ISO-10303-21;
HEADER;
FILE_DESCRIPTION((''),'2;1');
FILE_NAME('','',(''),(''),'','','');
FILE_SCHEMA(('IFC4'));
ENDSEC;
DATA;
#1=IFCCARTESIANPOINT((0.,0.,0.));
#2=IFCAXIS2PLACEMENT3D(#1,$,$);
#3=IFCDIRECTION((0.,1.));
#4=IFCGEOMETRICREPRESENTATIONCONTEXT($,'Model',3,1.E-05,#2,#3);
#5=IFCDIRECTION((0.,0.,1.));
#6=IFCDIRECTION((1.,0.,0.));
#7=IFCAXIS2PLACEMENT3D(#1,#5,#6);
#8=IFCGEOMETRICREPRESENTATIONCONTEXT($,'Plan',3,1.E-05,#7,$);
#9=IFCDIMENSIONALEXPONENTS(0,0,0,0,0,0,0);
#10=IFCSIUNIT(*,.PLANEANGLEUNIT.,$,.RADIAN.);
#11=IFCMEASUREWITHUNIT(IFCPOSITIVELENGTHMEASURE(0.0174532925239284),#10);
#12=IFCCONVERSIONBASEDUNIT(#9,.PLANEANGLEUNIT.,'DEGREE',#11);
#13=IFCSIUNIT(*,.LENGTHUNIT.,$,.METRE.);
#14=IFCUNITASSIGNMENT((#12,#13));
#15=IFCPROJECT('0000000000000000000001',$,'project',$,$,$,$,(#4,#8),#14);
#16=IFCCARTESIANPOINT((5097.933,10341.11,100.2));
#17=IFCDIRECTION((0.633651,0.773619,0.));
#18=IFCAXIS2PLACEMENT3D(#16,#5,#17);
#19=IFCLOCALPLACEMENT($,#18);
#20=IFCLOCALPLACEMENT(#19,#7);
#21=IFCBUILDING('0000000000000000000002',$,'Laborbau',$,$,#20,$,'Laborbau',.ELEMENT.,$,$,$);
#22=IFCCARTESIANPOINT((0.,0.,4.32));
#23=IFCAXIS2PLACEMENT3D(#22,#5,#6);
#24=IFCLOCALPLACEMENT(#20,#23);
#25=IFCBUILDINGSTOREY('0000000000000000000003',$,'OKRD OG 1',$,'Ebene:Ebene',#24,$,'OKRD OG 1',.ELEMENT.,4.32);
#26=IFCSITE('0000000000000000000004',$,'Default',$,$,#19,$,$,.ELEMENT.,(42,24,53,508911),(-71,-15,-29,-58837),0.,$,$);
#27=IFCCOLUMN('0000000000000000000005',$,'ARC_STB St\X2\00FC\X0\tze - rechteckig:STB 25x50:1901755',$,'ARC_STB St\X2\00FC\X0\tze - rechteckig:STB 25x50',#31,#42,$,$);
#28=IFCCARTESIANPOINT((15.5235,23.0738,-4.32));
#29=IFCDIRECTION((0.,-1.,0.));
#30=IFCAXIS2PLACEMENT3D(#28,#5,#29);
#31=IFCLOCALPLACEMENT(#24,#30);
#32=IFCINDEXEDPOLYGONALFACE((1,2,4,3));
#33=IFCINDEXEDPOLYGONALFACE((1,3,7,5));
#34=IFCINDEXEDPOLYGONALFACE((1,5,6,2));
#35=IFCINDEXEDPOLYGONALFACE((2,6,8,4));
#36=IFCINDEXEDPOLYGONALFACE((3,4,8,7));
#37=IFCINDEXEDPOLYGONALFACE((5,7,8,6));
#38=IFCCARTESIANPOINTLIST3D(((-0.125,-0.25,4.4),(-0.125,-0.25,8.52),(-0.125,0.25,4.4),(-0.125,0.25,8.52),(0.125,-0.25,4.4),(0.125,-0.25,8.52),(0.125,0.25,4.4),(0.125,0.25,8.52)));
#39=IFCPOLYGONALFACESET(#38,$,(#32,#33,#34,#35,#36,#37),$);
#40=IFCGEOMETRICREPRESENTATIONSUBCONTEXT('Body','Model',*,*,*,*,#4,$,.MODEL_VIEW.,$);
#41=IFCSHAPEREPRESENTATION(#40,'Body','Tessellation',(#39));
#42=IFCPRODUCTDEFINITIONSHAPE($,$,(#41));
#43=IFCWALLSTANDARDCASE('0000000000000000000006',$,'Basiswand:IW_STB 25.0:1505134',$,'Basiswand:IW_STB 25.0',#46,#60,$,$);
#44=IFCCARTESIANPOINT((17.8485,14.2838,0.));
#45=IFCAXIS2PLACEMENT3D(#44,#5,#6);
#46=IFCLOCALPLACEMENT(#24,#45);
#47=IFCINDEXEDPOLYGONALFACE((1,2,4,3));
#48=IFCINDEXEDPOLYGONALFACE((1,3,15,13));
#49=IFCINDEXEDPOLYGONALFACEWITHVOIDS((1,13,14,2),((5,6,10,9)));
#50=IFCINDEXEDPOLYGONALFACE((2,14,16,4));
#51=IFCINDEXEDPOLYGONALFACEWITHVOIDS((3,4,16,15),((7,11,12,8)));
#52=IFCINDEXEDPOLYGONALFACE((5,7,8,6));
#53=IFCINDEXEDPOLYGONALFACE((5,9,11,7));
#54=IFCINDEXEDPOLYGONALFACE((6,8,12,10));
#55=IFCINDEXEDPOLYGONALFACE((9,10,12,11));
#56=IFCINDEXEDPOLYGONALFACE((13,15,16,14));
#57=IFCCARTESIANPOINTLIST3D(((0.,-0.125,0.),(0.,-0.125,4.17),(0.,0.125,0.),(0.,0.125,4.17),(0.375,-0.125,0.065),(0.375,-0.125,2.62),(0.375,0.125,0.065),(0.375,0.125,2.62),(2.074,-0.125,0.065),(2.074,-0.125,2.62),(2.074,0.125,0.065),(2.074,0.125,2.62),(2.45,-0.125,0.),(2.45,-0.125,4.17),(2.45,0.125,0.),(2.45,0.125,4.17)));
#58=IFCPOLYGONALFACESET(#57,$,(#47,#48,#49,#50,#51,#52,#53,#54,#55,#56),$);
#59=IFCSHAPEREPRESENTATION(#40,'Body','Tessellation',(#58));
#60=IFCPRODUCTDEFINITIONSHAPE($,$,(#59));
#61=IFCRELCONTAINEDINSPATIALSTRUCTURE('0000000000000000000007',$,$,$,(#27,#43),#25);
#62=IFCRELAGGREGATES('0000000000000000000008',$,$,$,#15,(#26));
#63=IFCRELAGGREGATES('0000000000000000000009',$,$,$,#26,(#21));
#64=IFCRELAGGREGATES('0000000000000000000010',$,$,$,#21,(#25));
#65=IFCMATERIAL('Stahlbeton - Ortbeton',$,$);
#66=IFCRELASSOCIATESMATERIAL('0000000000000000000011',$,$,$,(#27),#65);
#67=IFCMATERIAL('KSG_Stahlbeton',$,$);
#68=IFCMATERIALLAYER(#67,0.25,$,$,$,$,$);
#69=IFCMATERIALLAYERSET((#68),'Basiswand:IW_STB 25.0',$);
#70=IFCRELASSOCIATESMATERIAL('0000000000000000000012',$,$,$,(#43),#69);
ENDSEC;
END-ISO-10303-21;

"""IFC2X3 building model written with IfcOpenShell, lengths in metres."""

from ifc_helpers import new_model, entity, si_unit, converted_unit, direction, frame, frame_2d, origin, origin_with_axes, origin_2d_with_axis, place, context, subcontext, project, spatial, rectangle, extrude, source, transform, mapped, material, layer, layer_set, layer_usage, element, save


model = new_model("IFC2X3")

# Units and contexts
model_context = context("Model", 3, precision=1e-05, world=origin(), true_north=direction((0.0, 1.0)))
plan_context = context("Plan", 3, precision=1e-05, world=origin_with_axes())
body_context = subcontext(model_context, "Body", "Model", "MODEL_VIEW")
ifc_project = project(units=[converted_unit("PLANEANGLEUNIT", "DEGREE", entity("IfcPositiveLengthMeasure", 0.0174532925239284), si_unit("PLANEANGLEUNIT", "RADIAN"), dimensions=[0, 0, 0, 0, 0, 0, 0]), si_unit("LENGTHUNIT", "METRE")], contexts=[model_context, plan_context])

# Site, building, storey
site_placement = place(None, frame((5097.933, 10341.11, 100.2), z_axis=(0.0, 0.0, 1.0), x_axis=(0.633651, 0.773619, 0.0)))
site = spatial("IfcSite", under=ifc_project, at=site_placement, Name="Default", CompositionType="ELEMENT", RefLatitude=(42, 24, 53, 508911), RefLongitude=(-71, -15, -29, -58837), RefElevation=0.0)
building_placement = place(site_placement, origin_with_axes())
building = spatial("IfcBuilding", under=site, at=building_placement, Name="Laborbau", LongName="Laborbau", CompositionType="ELEMENT")
storey_placement = place(building_placement, frame((0.0, 0.0, 4.32), z_axis=(0.0, 0.0, 1.0), x_axis=(1.0, 0.0, 0.0)))
storey = spatial("IfcBuildingStorey", under=building, at=storey_placement, Name="OKRD OG 1", ObjectType="Ebene:Ebene", LongName="OKRD OG 1", CompositionType="ELEMENT", Elevation=4.32)

# Column
ifc_material_1 = material(Name="Stahlbeton - Ortbeton")
shared_shape = source(origin(), body_context, "Body", "SweptSolid", [
    extrude(rectangle(XDim=0.5, YDim=0.25, at=origin_2d_with_axis()), frame((0.0, 0.0, 4.4), z_axis=(0.0, 0.0, 1.0), x_axis=(0.0, -1.0, 0.0)), (0.0, 0.0, 1.0), 4.12),
])
column_placement = place(storey_placement, frame((15.5235, 23.0738, -4.32), z_axis=(0.0, 0.0, 1.0), x_axis=(0.0, -1.0, 0.0)))
element("IfcColumn", 1, at=column_placement, inside=storey, material=ifc_material_1, Name="ARC_STB Stütze - rechteckig:STB 25x50:1901755", ObjectType="ARC_STB Stütze - rechteckig:STB 25x50", context=body_context, shape_type="MappedRepresentation", body=[
    mapped(shared_shape, transform((0.0, 0.0, 0.0), scale=1.0)),
])

# Shared definitions
ifc_material_2 = material(Name="KSG_Stahlbeton")
ifc_layer_1 = layer(ifc_material_2, 0.25)
ifc_layer_set_1 = layer_set([ifc_layer_1], Name="Basiswand:IW_STB 25.0")

# Wall, openings
ifc_layer_usage_1 = layer_usage(ifc_layer_set_1, "AXIS2", "NEGATIVE", 0.125)
wall_1_placement = place(storey_placement, frame((17.8485, 14.2838, 0.0), z_axis=(0.0, 0.0, 1.0), x_axis=(1.0, 0.0, 0.0)))
wall_1 = element("IfcWallStandardCase", 2, at=wall_1_placement, inside=storey, material=ifc_layer_usage_1, Name="Basiswand:IW_STB 25.0:1505134", ObjectType="Basiswand:IW_STB 25.0", context=body_context, shape_type="SweptSolid", body=[
    extrude(rectangle(XDim=2.45, YDim=0.25, at=frame_2d((1.225, 0.0), x_axis=(-1.0, 0.0))), origin(), (0.0, 0.0, 1.0), 4.17),
])
opening_1_placement = place(wall_1_placement, origin_with_axes())
element("IfcOpeningElement", 3, at=opening_1_placement, cuts=wall_1, ObjectType="Opening", context=body_context, shape_type="SweptSolid", body=[
    extrude(rectangle(XDim=2.4, YDim=1.3983, at=frame_2d((0.0, 0.0), x_axis=(1.0, 0.0))), frame((1.2254, -0.125, 1.32), z_axis=(0.0, 1.0, 0.0), x_axis=(0.0, 0.0, -1.0)), (0.0, 0.0, 1.0), 0.25),
])
opening_2_placement = place(wall_1_placement, origin_with_axes())
element("IfcOpeningElement", 4, at=opening_2_placement, cuts=wall_1, ObjectType="Opening", context=body_context, shape_type="SweptSolid", body=[
    extrude(rectangle(XDim=2.555, YDim=1.699, at=frame_2d((0.0, 0.0), x_axis=(1.0, 0.0))), frame((1.2245, -0.125, 1.3425), z_axis=(0.0, 1.0, 0.0), x_axis=(0.0, 0.0, -1.0)), (0.0, 0.0, 1.0), 0.25),
])

save(model, "model.ifc")
